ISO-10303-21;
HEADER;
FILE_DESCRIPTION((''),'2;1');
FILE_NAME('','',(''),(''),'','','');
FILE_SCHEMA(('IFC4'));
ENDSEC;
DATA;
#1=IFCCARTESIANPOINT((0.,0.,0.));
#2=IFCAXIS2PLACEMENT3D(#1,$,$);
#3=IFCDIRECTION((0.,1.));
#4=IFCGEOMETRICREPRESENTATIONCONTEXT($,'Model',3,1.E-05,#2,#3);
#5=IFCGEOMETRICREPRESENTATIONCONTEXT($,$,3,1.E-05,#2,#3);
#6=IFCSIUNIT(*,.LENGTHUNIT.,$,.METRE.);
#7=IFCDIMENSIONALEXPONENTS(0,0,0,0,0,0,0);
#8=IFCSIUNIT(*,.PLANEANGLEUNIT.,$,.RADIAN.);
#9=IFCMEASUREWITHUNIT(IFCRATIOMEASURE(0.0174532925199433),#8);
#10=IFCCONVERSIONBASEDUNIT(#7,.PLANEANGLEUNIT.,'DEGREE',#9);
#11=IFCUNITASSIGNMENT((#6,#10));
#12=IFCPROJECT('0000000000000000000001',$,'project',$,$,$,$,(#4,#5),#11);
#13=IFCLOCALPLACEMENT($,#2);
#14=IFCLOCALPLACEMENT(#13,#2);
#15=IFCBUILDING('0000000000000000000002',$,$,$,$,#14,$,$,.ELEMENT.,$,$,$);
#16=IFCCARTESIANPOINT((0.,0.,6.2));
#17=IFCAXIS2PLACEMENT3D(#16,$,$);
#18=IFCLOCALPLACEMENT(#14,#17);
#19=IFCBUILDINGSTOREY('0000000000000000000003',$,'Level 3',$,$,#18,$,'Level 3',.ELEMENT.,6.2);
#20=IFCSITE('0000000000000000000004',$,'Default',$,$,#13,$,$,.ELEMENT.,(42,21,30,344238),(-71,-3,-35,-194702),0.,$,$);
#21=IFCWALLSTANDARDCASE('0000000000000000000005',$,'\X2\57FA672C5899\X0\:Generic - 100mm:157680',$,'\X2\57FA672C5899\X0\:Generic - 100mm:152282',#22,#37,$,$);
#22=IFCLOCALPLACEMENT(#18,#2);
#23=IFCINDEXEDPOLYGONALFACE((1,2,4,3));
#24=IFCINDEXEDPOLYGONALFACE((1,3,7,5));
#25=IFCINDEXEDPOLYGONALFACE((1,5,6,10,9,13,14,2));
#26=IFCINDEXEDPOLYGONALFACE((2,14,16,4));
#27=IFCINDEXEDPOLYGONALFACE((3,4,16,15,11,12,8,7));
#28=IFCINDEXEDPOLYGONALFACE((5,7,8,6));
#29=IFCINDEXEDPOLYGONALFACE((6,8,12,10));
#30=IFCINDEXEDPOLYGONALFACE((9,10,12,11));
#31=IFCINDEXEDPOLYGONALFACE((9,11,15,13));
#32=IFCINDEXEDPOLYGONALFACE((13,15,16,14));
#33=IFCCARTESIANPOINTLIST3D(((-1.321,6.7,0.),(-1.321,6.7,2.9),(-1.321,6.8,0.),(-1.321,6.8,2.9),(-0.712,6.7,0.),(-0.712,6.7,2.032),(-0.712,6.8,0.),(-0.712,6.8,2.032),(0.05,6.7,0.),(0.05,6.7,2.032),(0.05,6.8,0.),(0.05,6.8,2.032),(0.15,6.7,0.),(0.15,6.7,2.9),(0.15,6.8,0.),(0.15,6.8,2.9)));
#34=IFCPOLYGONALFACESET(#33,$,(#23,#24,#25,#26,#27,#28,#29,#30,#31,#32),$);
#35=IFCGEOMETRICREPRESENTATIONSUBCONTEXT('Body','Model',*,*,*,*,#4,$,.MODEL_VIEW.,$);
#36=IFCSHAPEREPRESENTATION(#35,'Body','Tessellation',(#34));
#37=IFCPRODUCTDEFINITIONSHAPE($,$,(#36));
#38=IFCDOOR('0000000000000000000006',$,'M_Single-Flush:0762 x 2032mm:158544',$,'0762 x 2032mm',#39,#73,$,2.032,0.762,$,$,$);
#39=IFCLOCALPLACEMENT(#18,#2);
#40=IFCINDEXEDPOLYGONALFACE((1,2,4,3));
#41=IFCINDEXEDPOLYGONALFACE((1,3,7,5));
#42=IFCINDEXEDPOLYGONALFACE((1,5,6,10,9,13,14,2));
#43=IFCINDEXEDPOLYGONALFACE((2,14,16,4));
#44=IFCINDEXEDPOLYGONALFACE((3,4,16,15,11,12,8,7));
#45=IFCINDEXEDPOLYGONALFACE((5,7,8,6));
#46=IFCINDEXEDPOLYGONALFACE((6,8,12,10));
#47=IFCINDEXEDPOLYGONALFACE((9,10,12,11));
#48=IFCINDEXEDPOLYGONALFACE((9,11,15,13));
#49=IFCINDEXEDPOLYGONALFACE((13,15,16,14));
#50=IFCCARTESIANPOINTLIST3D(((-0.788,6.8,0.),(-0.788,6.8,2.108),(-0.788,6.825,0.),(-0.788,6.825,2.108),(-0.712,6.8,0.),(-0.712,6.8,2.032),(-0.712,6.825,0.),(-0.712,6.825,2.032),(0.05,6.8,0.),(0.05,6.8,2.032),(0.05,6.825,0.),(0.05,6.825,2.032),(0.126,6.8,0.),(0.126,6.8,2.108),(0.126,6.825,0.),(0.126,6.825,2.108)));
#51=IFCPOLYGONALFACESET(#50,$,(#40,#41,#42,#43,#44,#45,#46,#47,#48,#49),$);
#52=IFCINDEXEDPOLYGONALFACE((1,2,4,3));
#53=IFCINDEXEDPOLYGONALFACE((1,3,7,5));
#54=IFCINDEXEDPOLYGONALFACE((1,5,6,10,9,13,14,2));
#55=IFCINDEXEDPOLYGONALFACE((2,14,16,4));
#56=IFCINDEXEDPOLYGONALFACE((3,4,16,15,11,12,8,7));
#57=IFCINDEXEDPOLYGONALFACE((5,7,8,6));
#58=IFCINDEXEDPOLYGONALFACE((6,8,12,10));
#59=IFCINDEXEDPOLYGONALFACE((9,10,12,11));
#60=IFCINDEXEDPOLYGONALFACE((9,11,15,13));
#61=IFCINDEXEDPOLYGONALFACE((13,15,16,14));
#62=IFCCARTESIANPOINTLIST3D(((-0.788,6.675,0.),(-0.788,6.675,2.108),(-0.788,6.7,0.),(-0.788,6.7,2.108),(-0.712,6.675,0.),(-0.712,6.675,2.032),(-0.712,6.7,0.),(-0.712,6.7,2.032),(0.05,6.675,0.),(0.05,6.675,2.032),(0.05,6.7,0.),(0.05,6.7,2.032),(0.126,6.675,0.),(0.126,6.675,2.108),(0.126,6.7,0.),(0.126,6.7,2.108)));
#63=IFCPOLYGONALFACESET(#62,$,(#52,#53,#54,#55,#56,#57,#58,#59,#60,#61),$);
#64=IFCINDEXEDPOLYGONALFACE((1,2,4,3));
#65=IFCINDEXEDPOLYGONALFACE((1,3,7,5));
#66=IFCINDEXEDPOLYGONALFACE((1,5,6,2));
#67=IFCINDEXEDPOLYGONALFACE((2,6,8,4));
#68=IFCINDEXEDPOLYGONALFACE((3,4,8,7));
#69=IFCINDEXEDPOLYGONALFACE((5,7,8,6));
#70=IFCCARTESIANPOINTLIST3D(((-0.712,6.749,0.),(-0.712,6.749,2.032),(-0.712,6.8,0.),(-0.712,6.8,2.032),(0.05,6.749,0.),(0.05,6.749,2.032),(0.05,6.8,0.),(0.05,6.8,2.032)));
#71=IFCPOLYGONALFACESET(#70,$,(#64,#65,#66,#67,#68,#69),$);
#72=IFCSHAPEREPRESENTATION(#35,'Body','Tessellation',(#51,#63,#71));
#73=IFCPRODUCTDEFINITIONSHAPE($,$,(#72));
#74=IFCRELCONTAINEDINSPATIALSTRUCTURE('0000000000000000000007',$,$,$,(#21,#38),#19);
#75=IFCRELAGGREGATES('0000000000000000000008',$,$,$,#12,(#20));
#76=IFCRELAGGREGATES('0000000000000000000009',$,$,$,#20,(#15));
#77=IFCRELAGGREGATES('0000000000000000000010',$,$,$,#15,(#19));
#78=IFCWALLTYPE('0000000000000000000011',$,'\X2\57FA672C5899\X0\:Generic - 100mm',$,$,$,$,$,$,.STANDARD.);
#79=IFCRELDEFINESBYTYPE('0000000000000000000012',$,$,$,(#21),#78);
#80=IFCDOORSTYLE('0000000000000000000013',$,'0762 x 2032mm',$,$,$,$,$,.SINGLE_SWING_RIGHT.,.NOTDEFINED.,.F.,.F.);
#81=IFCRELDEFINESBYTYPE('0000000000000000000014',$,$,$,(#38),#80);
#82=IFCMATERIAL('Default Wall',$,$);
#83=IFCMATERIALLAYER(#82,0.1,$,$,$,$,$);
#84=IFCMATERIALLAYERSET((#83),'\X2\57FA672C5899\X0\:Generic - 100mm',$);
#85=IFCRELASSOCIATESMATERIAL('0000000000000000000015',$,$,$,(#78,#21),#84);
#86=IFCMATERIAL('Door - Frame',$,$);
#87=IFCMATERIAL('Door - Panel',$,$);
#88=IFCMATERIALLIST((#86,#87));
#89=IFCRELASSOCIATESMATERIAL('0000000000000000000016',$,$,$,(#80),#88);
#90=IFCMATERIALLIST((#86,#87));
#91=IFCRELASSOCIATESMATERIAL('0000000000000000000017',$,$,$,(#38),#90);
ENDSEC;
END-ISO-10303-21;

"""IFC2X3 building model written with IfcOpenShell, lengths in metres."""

from ifc_helpers import new_model, entity, si_unit, converted_unit, direction, frame, frame_2d, origin, origin_2d_with_axis, place, context, subcontext, project, spatial, polyline, rectangle, outline, extrude, clip, bounded_halfspace, source, transform, mapped, material, material_list, layer, layer_set, layer_usage, type_object, type_shapes, element, fill, save


model = new_model("IFC2X3")

# Units and contexts
model_context = context("Model", 3, precision=1e-05, world=origin(), true_north=direction((0.0, 1.0)))
context_of_model = context(None, 3, precision=1e-05, world=origin(), true_north=direction((0.0, 1.0)))
body_context = subcontext(model_context, "Body", "Model", "MODEL_VIEW")
ifc_project = project(units=[si_unit("LENGTHUNIT", "METRE"), converted_unit("PLANEANGLEUNIT", "DEGREE", entity("IfcRatioMeasure", 0.0174532925199433), si_unit("PLANEANGLEUNIT", "RADIAN"), dimensions=[0, 0, 0, 0, 0, 0, 0])], contexts=[model_context, context_of_model])

# Site, building, storey
site_placement = place(None, origin())
site = spatial("IfcSite", under=ifc_project, at=site_placement, Name="Default", CompositionType="ELEMENT", RefLatitude=(42, 21, 30, 344238), RefLongitude=(-71, -3, -35, -194702), RefElevation=0.0)
building_placement = place(site_placement, origin())
building = spatial("IfcBuilding", under=site, at=building_placement, CompositionType="ELEMENT")
storey_placement = place(building_placement, frame((0.0, 0.0, 6.2)))
storey = spatial("IfcBuildingStorey", under=building, at=storey_placement, Name="Level 3", LongName="Level 3", CompositionType="ELEMENT", Elevation=6.2)

# Shared definitions
ifc_material_1 = material(Name="Default Wall")

# Shared definitions
ifc_material_2 = material(Name="Door - Panel")
ifc_material_3 = material(Name="Door - Frame")

# Shared definitions
ifc_layer_1 = layer(ifc_material_1, 0.1)
ifc_layer_set_1 = layer_set([ifc_layer_1], Name="基本墙:Generic - 100mm")
wall_type_1 = type_object("IfcWallType", Name="基本墙:Generic - 100mm", PredefinedType="STANDARD", material=ifc_layer_set_1)

# Shared definitions
ifc_material_list_1 = material_list([ifc_material_3, ifc_material_2])
door_style_1 = type_object("IfcDoorStyle", Name="0762 x 2032mm", ConstructionType="NOTDEFINED", OperationType="SINGLE_SWING_RIGHT", ParameterTakesPrecedence=False, Sizeable=False, material=ifc_material_list_1)
shared_shape_1 = source(origin(), body_context, "Body", "SweptSolid", [
    extrude(outline(polyline([(-0.457, -1.073), (0.457, -1.073), (0.457, 1.035), (0.381, 1.035), (0.381, -0.997), (-0.381, -0.997), (-0.381, 1.035), (-0.457, 1.035), (-0.457, -1.073)])), frame((0.381, 0.1, 1.035), z_axis=(0.0, 1.0, 0.0), x_axis=(1.0, 0.0, 0.0)), (0.0, 0.0, 1.0), 0.025),
    extrude(outline(polyline([(-1.073, -0.457), (1.035, -0.457), (1.035, -0.381), (-0.997, -0.381), (-0.997, 0.381), (1.035, 0.381), (1.035, 0.457), (-1.073, 0.457), (-1.073, -0.457)])), frame((0.381, -0.025, 1.035), z_axis=(0.0, 1.0, 0.0), x_axis=(0.0, 0.0, -1.0)), (0.0, 0.0, 1.0), 0.025),
    extrude(rectangle(XDim=0.051, YDim=0.762, at=origin_2d_with_axis()), frame((0.381, 0.0745, 0.0), z_axis=(0.0, 0.0, 1.0), x_axis=(0.0, 1.0, 0.0)), (0.0, 0.0, 1.0), 2.032),
])
type_shapes(door_style_1, [shared_shape_1])

# Wall, opening, door
ifc_layer_usage_1 = layer_usage(ifc_layer_set_1, "AXIS2", "POSITIVE", -0.05)
wall_1_placement = place(storey_placement, frame((-1.321, 6.75, 0.0)))
wall_1 = element("IfcWallStandardCase", 1, at=wall_1_placement, inside=storey, type_object=wall_type_1, material=ifc_layer_usage_1, Name="基本墙:Generic - 100mm:157680", ObjectType="基本墙:Generic - 100mm:152282", context=body_context, shape_type="Clipping", body=[
    clip(extrude(rectangle(XDim=1.471, YDim=0.1, at=frame_2d((0.7355, 0.0), x_axis=(-1.0, 0.0))), origin(), (0.0, 0.0, 1.0), 3.2), bounded_halfspace(frame((0.0, -0.05, 2.9), z_axis=(0.0, 0.0, -1.0), x_axis=(0.0, -1.0, 0.0)), True, frame((0.0, -0.05, 2.9), z_axis=(0.0, 0.0, -1.0), x_axis=(0.0, -1.0, 0.0)), polyline([(0.0, 0.0), (-0.1, 0.0), (-0.1, -1.471), (0.0, -1.471), (0.0, 0.0)]))),
])
opening_1_placement = place(wall_1_placement, frame((0.609, -0.05, 0.0)))
opening_1 = element("IfcOpeningElement", 2, at=opening_1_placement, cuts=wall_1, ObjectType="Opening", context=body_context, shape_type="SweptSolid", body=[
    extrude(rectangle(XDim=0.762, YDim=2.032, at=frame_2d((1.016, 0.381), x_axis=(0.0, 1.0))), frame((0.0, 0.0, 0.0), z_axis=(0.0, 1.0, 0.0), x_axis=(0.0, 0.0, 1.0)), (0.0, 0.0, 1.0), 0.1),
])
ifc_material_list_2 = material_list([ifc_material_3, ifc_material_2])
door_1_placement = place(opening_1_placement, origin())
door_1 = element("IfcDoor", 3, at=door_1_placement, inside=storey, type_object=door_style_1, material=ifc_material_list_2, Name="M_Single-Flush:0762 x 2032mm:158544", ObjectType="0762 x 2032mm", OverallHeight=2.032, OverallWidth=0.762, context=body_context, shape_type="MappedRepresentation", body=[
    mapped(shared_shape_1, transform((0.0, 0.0, 0.0), scale=1.0)),
])
fill(opening_1, door_1)

save(model, "model.ifc")
